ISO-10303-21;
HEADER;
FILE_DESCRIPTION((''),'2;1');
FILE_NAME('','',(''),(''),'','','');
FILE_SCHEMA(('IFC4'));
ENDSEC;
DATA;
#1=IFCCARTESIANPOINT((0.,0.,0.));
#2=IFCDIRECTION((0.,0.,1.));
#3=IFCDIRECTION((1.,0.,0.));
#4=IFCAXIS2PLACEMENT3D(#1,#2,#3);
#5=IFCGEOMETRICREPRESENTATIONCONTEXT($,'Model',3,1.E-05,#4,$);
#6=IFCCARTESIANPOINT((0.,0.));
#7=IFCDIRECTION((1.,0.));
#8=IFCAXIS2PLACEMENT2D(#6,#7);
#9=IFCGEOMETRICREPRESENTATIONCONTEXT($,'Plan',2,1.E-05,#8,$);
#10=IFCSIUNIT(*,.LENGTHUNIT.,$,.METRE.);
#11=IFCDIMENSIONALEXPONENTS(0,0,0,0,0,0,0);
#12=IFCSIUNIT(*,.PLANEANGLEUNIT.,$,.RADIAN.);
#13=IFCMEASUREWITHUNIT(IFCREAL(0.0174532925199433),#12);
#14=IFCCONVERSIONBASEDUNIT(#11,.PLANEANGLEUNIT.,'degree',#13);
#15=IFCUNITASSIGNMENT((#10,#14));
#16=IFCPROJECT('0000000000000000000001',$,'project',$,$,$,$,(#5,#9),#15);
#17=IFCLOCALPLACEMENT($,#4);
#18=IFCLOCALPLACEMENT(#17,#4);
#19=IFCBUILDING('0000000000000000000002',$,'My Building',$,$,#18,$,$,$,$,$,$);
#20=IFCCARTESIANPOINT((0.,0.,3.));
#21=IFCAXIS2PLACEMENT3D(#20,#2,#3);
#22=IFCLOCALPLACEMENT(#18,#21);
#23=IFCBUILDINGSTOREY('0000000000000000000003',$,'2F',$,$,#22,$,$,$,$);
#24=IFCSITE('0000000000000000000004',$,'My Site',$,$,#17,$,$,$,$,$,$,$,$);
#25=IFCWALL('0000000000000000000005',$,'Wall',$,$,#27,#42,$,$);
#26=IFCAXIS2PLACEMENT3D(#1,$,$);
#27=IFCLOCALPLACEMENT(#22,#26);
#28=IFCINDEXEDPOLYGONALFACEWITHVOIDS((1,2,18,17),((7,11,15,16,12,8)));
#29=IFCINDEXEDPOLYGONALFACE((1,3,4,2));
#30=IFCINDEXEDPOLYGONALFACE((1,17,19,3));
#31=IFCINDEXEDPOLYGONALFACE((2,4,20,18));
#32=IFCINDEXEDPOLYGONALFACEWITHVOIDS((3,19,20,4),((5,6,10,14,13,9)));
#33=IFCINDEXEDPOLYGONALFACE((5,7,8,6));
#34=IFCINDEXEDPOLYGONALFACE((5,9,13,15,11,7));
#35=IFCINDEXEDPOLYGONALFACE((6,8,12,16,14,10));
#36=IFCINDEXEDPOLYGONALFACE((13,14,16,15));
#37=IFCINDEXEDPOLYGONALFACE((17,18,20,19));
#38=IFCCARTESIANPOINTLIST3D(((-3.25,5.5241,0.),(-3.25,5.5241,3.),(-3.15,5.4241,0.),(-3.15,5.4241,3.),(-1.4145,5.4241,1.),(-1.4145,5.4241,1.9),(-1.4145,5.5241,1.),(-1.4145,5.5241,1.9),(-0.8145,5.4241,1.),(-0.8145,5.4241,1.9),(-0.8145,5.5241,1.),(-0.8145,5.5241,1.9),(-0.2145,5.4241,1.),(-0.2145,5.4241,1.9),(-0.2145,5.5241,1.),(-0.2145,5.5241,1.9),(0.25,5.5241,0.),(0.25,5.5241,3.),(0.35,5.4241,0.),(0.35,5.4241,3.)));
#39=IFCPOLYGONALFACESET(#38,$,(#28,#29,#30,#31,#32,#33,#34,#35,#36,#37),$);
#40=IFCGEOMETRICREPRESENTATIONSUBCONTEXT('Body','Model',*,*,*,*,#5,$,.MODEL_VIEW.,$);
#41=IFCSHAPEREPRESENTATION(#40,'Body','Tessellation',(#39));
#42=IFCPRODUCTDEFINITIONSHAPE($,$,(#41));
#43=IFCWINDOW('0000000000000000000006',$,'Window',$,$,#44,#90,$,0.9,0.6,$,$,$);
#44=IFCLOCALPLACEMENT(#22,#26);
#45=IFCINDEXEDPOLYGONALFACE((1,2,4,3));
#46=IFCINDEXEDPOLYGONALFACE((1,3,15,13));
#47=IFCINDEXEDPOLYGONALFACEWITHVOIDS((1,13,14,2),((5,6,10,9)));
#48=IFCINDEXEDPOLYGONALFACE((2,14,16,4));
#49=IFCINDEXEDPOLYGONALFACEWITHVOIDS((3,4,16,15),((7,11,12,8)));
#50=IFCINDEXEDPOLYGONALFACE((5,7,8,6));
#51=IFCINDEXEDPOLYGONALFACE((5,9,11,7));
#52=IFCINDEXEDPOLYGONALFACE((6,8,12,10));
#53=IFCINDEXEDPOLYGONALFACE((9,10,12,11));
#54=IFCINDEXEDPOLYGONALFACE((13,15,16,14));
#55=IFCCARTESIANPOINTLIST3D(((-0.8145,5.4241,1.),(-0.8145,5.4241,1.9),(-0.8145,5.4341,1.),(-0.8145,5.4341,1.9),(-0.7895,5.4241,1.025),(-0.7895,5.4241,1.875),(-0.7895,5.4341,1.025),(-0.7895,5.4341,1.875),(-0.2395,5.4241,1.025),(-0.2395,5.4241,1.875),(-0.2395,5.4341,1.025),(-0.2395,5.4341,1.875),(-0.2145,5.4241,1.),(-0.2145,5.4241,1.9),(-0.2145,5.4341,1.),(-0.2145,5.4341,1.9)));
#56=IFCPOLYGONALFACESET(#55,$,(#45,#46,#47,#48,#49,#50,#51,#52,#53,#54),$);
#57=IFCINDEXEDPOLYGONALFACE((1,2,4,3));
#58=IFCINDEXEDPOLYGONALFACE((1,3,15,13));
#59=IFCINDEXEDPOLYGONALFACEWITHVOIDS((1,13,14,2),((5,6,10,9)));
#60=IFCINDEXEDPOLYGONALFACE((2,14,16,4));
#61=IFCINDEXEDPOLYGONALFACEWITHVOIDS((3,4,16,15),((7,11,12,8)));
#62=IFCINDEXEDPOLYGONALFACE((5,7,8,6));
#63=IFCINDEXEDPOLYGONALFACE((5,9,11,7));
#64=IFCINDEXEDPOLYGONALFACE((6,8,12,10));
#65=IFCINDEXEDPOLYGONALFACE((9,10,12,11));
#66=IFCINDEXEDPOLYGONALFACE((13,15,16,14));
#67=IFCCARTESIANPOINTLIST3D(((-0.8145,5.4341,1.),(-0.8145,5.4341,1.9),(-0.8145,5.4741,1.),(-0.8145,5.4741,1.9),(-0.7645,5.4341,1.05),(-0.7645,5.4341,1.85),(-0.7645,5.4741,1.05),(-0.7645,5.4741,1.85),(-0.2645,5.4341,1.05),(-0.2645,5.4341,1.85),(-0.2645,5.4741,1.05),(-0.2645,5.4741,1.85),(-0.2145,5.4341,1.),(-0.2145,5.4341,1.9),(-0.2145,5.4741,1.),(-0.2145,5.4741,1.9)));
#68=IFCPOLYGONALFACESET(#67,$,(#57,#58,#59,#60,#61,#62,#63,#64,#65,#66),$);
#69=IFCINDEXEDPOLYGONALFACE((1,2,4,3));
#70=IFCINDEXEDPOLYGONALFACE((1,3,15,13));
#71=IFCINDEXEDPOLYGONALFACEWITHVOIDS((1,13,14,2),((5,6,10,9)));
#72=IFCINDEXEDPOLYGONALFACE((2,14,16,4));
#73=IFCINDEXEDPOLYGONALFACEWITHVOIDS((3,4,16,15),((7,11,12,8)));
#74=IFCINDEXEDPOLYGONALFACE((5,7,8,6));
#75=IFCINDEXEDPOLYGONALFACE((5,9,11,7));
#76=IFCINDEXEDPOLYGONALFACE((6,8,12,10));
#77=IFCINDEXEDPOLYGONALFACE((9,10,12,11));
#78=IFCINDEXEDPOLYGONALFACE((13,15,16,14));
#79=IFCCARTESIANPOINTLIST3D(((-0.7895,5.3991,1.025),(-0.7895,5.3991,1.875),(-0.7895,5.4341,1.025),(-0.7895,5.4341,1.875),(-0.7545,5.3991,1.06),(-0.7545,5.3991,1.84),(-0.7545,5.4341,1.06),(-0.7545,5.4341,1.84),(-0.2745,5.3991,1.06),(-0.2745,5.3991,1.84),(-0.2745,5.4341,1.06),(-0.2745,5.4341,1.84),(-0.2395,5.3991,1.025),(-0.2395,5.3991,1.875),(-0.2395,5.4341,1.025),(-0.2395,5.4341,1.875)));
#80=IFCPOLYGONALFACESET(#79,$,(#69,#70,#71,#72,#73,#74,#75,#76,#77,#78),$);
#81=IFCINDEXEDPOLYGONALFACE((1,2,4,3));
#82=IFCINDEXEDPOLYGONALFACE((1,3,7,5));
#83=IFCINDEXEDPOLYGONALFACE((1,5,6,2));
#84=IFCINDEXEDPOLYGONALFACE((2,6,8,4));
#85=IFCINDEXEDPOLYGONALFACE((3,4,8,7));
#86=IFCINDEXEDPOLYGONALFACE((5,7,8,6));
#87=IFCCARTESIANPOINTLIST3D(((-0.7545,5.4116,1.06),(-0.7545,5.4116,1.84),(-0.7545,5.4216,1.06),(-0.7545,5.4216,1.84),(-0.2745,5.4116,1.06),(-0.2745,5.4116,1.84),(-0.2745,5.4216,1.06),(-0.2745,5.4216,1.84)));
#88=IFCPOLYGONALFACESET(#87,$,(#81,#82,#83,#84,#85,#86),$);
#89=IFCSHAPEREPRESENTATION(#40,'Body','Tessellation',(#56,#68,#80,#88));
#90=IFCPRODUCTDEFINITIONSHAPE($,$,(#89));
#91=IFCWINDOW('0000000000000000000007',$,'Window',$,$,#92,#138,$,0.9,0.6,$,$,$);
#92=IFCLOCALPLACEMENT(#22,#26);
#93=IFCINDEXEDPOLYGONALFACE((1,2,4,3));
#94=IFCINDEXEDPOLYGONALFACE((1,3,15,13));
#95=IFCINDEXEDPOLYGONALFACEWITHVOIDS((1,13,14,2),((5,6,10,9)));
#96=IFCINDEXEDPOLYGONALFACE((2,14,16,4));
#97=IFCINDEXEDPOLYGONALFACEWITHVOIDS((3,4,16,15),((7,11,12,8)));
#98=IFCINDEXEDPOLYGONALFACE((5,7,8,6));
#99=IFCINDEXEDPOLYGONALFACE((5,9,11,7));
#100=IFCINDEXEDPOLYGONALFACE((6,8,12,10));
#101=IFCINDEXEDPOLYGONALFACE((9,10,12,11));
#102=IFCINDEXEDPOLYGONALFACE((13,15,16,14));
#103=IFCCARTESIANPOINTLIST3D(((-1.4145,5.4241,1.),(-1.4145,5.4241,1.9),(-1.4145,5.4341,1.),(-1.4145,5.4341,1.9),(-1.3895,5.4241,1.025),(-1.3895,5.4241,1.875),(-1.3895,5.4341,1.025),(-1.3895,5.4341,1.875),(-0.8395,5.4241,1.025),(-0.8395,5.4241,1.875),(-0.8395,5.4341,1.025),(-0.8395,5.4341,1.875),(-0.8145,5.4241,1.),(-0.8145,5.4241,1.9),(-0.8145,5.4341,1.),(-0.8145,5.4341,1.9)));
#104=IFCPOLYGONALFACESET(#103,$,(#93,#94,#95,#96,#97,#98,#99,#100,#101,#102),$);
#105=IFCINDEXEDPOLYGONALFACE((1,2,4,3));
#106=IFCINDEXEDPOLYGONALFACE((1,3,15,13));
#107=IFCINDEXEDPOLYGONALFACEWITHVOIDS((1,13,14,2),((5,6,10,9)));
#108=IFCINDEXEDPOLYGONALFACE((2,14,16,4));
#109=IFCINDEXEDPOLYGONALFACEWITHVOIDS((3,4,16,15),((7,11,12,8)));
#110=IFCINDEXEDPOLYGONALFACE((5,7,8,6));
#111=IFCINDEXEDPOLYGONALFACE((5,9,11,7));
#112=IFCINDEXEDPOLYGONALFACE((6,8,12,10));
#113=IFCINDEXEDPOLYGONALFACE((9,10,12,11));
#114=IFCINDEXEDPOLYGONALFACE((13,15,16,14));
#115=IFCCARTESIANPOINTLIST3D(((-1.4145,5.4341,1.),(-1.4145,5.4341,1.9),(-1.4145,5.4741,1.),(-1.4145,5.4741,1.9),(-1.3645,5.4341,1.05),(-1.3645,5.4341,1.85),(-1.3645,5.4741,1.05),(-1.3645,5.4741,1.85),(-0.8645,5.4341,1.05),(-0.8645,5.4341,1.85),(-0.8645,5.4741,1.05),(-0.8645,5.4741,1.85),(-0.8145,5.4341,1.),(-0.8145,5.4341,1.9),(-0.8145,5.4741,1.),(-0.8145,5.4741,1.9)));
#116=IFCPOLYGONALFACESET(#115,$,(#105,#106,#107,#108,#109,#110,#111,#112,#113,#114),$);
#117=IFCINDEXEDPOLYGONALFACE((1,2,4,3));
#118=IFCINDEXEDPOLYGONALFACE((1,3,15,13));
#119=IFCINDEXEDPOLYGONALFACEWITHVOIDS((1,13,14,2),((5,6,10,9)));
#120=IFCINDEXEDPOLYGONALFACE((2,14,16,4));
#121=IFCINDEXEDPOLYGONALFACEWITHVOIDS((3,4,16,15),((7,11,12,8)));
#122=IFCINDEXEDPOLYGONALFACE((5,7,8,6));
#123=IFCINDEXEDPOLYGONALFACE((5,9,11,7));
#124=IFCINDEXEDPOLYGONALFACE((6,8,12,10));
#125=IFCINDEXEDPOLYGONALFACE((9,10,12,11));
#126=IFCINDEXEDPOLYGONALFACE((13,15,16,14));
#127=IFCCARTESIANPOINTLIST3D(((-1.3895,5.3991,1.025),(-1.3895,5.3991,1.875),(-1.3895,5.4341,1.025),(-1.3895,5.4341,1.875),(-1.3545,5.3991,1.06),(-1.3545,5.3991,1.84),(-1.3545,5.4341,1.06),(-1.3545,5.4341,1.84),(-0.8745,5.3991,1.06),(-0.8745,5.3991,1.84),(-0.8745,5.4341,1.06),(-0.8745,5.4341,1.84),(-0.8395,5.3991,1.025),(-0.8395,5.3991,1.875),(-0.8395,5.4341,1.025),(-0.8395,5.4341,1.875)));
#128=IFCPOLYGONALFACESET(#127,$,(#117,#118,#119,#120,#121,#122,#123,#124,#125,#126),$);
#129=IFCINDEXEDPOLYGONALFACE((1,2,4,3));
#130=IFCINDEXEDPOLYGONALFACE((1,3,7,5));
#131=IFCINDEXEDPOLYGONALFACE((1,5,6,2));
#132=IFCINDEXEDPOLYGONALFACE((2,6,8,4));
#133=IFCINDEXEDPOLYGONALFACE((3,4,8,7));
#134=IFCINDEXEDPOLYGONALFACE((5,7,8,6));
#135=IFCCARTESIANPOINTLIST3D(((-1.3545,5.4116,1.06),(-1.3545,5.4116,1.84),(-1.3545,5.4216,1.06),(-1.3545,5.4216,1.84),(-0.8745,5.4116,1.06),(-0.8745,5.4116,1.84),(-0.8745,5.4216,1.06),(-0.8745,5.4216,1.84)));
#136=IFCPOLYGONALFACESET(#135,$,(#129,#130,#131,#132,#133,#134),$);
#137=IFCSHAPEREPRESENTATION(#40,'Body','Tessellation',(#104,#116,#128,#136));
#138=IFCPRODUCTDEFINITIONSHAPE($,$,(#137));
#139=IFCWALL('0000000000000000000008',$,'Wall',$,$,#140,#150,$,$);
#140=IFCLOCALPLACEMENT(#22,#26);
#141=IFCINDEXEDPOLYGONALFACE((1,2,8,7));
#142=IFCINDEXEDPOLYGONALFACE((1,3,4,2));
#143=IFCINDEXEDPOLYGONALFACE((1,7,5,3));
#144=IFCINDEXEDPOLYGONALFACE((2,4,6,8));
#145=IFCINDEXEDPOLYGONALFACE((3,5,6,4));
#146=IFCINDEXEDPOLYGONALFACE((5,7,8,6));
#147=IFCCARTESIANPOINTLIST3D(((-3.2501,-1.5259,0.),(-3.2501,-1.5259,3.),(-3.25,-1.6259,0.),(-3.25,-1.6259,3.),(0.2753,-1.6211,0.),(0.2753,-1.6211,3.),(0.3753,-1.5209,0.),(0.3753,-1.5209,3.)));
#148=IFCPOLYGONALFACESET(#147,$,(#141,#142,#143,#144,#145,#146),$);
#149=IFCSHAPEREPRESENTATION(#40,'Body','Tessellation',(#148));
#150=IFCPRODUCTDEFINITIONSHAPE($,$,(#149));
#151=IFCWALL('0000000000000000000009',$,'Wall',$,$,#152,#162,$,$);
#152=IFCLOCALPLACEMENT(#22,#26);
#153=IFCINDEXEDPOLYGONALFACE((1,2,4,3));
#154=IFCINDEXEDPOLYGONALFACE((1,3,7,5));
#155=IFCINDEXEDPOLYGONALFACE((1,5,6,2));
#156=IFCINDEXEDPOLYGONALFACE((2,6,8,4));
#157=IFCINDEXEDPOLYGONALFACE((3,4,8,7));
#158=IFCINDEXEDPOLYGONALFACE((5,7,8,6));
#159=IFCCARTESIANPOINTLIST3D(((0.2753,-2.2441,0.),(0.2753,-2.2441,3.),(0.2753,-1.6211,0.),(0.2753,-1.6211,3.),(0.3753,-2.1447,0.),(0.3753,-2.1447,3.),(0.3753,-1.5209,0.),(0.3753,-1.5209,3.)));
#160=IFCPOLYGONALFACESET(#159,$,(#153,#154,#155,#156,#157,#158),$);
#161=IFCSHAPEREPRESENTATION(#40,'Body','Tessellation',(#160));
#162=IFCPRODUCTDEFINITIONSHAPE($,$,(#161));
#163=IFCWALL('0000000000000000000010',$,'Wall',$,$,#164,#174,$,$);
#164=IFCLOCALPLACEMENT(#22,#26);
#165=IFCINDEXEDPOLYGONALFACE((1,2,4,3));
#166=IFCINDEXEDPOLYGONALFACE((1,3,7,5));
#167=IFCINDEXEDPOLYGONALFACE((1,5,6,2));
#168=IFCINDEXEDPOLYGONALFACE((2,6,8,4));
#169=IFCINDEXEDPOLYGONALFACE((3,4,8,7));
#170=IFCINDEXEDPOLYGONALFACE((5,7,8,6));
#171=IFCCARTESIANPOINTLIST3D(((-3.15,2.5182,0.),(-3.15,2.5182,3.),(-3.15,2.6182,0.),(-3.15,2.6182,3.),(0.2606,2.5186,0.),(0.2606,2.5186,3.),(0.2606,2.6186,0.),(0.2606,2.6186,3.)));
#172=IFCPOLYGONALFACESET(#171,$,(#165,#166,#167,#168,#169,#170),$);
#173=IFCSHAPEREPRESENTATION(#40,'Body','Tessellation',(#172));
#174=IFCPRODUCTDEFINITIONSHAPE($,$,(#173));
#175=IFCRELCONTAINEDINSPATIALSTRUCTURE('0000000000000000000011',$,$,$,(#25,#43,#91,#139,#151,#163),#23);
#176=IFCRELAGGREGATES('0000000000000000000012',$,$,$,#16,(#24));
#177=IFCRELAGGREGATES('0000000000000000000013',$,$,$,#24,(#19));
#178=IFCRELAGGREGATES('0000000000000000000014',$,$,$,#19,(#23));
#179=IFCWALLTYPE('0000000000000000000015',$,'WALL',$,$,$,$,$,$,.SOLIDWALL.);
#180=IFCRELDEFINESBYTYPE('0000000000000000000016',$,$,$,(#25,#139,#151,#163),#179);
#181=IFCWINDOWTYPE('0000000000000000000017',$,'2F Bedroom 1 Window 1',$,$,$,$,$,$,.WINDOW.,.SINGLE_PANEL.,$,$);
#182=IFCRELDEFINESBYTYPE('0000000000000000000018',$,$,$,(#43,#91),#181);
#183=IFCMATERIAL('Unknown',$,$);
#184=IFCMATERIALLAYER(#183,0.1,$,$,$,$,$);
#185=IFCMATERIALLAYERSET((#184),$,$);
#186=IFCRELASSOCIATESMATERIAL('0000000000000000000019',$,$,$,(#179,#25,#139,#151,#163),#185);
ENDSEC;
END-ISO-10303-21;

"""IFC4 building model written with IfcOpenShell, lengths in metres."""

from ifc_helpers import new_model, entity, si_unit, converted_unit, frame, origin_with_axes, origin_2d_with_axis, place, context, subcontext, project, spatial, line, indexed_curve, outline, extrude, shape, source, transform, mapped, material, layer, layer_set, layer_usage, type_object, type_shapes, element, fill, save


model = new_model("IFC4")

# Units and contexts
model_context = context("Model", 3, precision=1e-05, world=origin_with_axes())
plan_context = context("Plan", 2, precision=1e-05, world=origin_2d_with_axis())
body_context_1 = subcontext(model_context, "Body", "Model", "MODEL_VIEW")
body_context_2 = subcontext(plan_context, "Body", "Plan", "PLAN_VIEW")
ifc_project = project(units=[si_unit("LENGTHUNIT", "METRE"), converted_unit("PLANEANGLEUNIT", "degree", entity("IfcReal", 0.0174532925199433), si_unit("PLANEANGLEUNIT", "RADIAN"), dimensions=[0, 0, 0, 0, 0, 0, 0])], contexts=[model_context, plan_context])

# Site, building, storey
site_placement = place(None, origin_with_axes())
site = spatial("IfcSite", under=ifc_project, at=site_placement, Name="My Site")
building_placement = place(site_placement, origin_with_axes())
building = spatial("IfcBuilding", under=site, at=building_placement, Name="My Building")
storey_placement = place(building_placement, frame((0.0, 0.0, 3.0), z_axis=(0.0, 0.0, 1.0), x_axis=(1.0, 0.0, 0.0)))
storey = spatial("IfcBuildingStorey", under=building, at=storey_placement, Name="2F")

# Shared definitions
ifc_material = material(Name="Unknown")

# Shared definitions
ifc_layer_1 = layer(ifc_material, 0.1)
ifc_layer_set_1 = layer_set([ifc_layer_1])
wall_type = type_object("IfcWallType", Name="WALL", PredefinedType="SOLIDWALL", material=ifc_layer_set_1)

# Wall, openings, windows
ifc_layer_usage_1 = layer_usage(ifc_layer_set_1, "AXIS2", "POSITIVE", 0.0)
wall_1_placement = place(storey_placement, frame((0.25, 5.5241, 0.0), z_axis=(0.0, 0.0, 1.0), x_axis=(-1.0, 0.0, 0.0)))
wall_1 = element("IfcWall", 1, at=wall_1_placement, inside=storey, type_object=wall_type, material=ifc_layer_usage_1, Name="Wall", context=body_context_1, shape_type="SweptSolid", body=[
    extrude(outline(indexed_curve([(0.0, 0.0), (-0.1, 0.1), (3.4, 0.1), (3.5, 0.0)], segments=[line(1, 2, 3, 4, 1)])), origin_with_axes(), (0.0, 0.0, 1.0), 3.0),
])
shared_shape_1 = source(origin_with_axes(), body_context_1, "Body", "SweptSolid", [
    extrude(outline(indexed_curve([(0.0, 0.0), (0.6, 0.0), (0.6, 0.9), (0.0, 0.9)], segments=[line(1, 2, 3, 4, 1)])), frame((0.0, -0.6, 0.0), z_axis=(0.0, -1.0, 0.0), x_axis=(1.0, 0.0, 0.0)), (0.0, 0.0, -1.0), 1.2),
])
opening_1_placement = place(wall_1_placement, frame((0.4645, 0.0, 1.0), z_axis=(0.0, 0.0, 1.0), x_axis=(1.0, 0.0, 0.0)))
opening_1 = element("IfcOpeningElement", 2, at=opening_1_placement, cuts=wall_1, PredefinedType="OPENING", context=body_context_1, shape_type="MappedRepresentation", body=[
    mapped(shared_shape_1, transform((0.0, 0.0, 0.0), x_axis=(1.0, 0.0, 0.0), y_axis=(0.0, 1.0, 0.0), z_axis=(0.0, 0.0, 1.0), scale=1.0)),
])
opening_2_placement = place(wall_1_placement, frame((1.0645, 0.0, 1.0), z_axis=(0.0, 0.0, 1.0), x_axis=(1.0, 0.0, 0.0)))
opening_2 = element("IfcOpeningElement", 3, at=opening_2_placement, cuts=wall_1, PredefinedType="OPENING", context=body_context_1, shape_type="MappedRepresentation", body=[
    mapped(shared_shape_1, transform((0.0, 0.0, 0.0), x_axis=(1.0, 0.0, 0.0), y_axis=(0.0, 1.0, 0.0), z_axis=(0.0, 0.0, 1.0), scale=1.0)),
])
window_type_1 = type_object("IfcWindowType", Name="2F Bedroom 1 Window 1", PartitioningType="SINGLE_PANEL", PredefinedType="WINDOW")
shared_shape_2 = source(origin_with_axes(), body_context_1, "Body", "SweptSolid", [
    extrude(outline(indexed_curve([(0.0, 0.0), (0.6, 0.0), (0.6, 0.9), (0.0, 0.9)], segments=[line(1, 2, 3, 4, 1)]), holes=[indexed_curve([(0.025, 0.025), (0.575, 0.025), (0.575, 0.875), (0.025, 0.875)], segments=[line(1, 2, 3, 4, 1)])]), frame((0.0, 0.09, 0.0), z_axis=(0.0, -1.0, 0.0), x_axis=(1.0, 0.0, 0.0)), (0.0, 0.0, -1.0), 0.01),
    extrude(outline(indexed_curve([(0.0, 0.0), (0.6, 0.0), (0.6, 0.9), (0.0, 0.9)], segments=[line(1, 2, 3, 4, 1)]), holes=[indexed_curve([(0.05, 0.05), (0.55, 0.05), (0.55, 0.85), (0.05, 0.85)], segments=[line(1, 2, 3, 4, 1)])]), frame((0.0, 0.05, 0.0), z_axis=(0.0, -1.0, 0.0), x_axis=(1.0, 0.0, 0.0)), (0.0, 0.0, -1.0), 0.04),
    extrude(outline(indexed_curve([(0.0, 0.0), (0.55, 0.0), (0.55, 0.85), (0.0, 0.85)], segments=[line(1, 2, 3, 4, 1)]), holes=[indexed_curve([(0.035, 0.035), (0.515, 0.035), (0.515, 0.815), (0.035, 0.815)], segments=[line(1, 2, 3, 4, 1)])]), frame((0.025, 0.09, 0.025), z_axis=(0.0, -1.0, 0.0), x_axis=(1.0, 0.0, 0.0)), (0.0, 0.0, -1.0), 0.035),
    extrude(outline(indexed_curve([(0.035, 0.035), (0.515, 0.035), (0.515, 0.815), (0.035, 0.815)], segments=[line(1, 2, 3, 4, 1)])), frame((0.025, 0.1025, 0.025), z_axis=(0.0, -1.0, 0.0), x_axis=(1.0, 0.0, 0.0)), (0.0, 0.0, -1.0), 0.01),
])
shared_shape_3 = source(origin_with_axes(), body_context_2, "Body", "Curve2D", [
    entity("IfcIndexedPolyCurve", entity("IfcCartesianPointList2D", [[0.05, 0.05], [0.55, 0.05]])),
    entity("IfcIndexedPolyCurve", entity("IfcCartesianPointList2D", [[0.0, 0.1], [0.025, 0.1], [0.025, 0.09], [0.05, 0.09], [0.05, 0.05], [0.0, 0.05]]), [entity("IfcLineIndex", [1, 2, 3, 4, 5, 6, 1])]),
    entity("IfcIndexedPolyCurve", entity("IfcCartesianPointList2D", [[0.6, 0.1], [0.575, 0.1], [0.575, 0.09], [0.55, 0.09], [0.55, 0.05], [0.6, 0.05]]), [entity("IfcLineIndex", [1, 2, 3, 4, 5, 6, 1])]),
    entity("IfcIndexedPolyCurve", entity("IfcCartesianPointList2D", [[0.025, 0.09], [0.06, 0.09], [0.06, 0.125], [0.025, 0.125]]), [entity("IfcLineIndex", [1, 2, 3, 4, 1])]),
    entity("IfcIndexedPolyCurve", entity("IfcCartesianPointList2D", [[0.575, 0.09], [0.54, 0.09], [0.54, 0.125], [0.575, 0.125]]), [entity("IfcLineIndex", [1, 2, 3, 4, 1])]),
    entity("IfcIndexedPolyCurve", entity("IfcCartesianPointList2D", [[0.06, 0.09], [0.54, 0.09]])),
    entity("IfcIndexedPolyCurve", entity("IfcCartesianPointList2D", [[0.06, 0.125], [0.54, 0.125]])),
    entity("IfcIndexedPolyCurve", entity("IfcCartesianPointList2D", [[0.06, 0.1075], [0.54, 0.1075]])),
])
type_shapes(window_type_1, [shared_shape_2, shared_shape_3])
window_1_placement = place(opening_1_placement, frame((0.0, 0.0, 0.0), z_axis=(0.0, 0.0, 1.0), x_axis=(1.0, 0.0, 0.0)))
window_1 = element("IfcWindow", 4, at=window_1_placement, inside=storey, type_object=window_type_1, Name="Window", OverallHeight=0.9, OverallWidth=0.6, shapes=[
    shape(body_context_1, "Body", "MappedRepresentation", [mapped(shared_shape_2, transform((0.0, 0.0, 0.0), x_axis=(1.0, 0.0, 0.0), y_axis=(0.0, 1.0, 0.0), z_axis=(0.0, 0.0, 1.0), scale=1.0))]),
    shape(body_context_2, "Body", "MappedRepresentation", [mapped(shared_shape_3, transform((0.0, 0.0, 0.0), x_axis=(1.0, 0.0, 0.0), y_axis=(0.0, 1.0, 0.0), z_axis=(0.0, 0.0, 1.0), scale=1.0))]),
])
fill(opening_1, window_1)
window_2_placement = place(opening_2_placement, frame((0.0, 0.0, 0.0), z_axis=(0.0, 0.0, 1.0), x_axis=(1.0, 0.0, 0.0)))
window_2 = element("IfcWindow", 5, at=window_2_placement, inside=storey, type_object=window_type_1, Name="Window", OverallHeight=0.9, OverallWidth=0.6, shapes=[
    shape(body_context_1, "Body", "MappedRepresentation", [mapped(shared_shape_2, transform((0.0, 0.0, 0.0), x_axis=(1.0, 0.0, 0.0), y_axis=(0.0, 1.0, 0.0), z_axis=(0.0, 0.0, 1.0), scale=1.0))]),
    shape(body_context_2, "Body", "MappedRepresentation", [mapped(shared_shape_3, transform((0.0, 0.0, 0.0), x_axis=(1.0, 0.0, 0.0), y_axis=(0.0, 1.0, 0.0), z_axis=(0.0, 0.0, 1.0), scale=1.0))]),
])
fill(opening_2, window_2)

# Walls
ifc_layer_usage_2 = layer_usage(ifc_layer_set_1, "AXIS2", "POSITIVE", 0.0)
wall_2_placement = place(storey_placement, frame((-3.25, -1.6259, 0.0), z_axis=(0.0, 0.0, 1.0), x_axis=(0.999999, 0.001371, 0.0)))
element("IfcWall", 6, at=wall_2_placement, inside=storey, type_object=wall_type, material=ifc_layer_usage_2, Name="Wall", context=body_context_1, shape_type="SweptSolid", body=[
    extrude(outline(indexed_curve([(0.0, 0.0), (0.0, 0.1), (3.6254, 0.1), (3.5253, 0.0)], segments=[line(1, 2, 3, 4, 1)])), origin_with_axes(), (0.0, 0.0, 1.0), 3.0),
])
ifc_layer_usage_3 = layer_usage(ifc_layer_set_1, "AXIS2", "POSITIVE", 0.0)
wall_3_placement = place(storey_placement, frame((0.2753, -1.6211, 0.0), z_axis=(0.0, 0.0, 1.0), x_axis=(0.0, -1.0, 0.0)))
element("IfcWall", 7, at=wall_3_placement, inside=storey, type_object=wall_type, material=ifc_layer_usage_3, Name="Wall", context=body_context_1, shape_type="SweptSolid", body=[
    extrude(outline(indexed_curve([(0.0, 0.0), (-0.1001, 0.1), (0.5237, 0.1), (0.623, 0.0)], segments=[line(1, 2, 3, 4, 1)])), origin_with_axes(), (0.0, 0.0, 1.0), 3.0),
])

# Wall
ifc_layer_usage_4 = layer_usage(ifc_layer_set_1, "AXIS2", "POSITIVE", 0.0)
wall_4_placement = place(storey_placement, frame((-3.15, 2.5182, 0.0), z_axis=(0.0, 0.0, 1.0), x_axis=(1.0, 0.000117, 0.0)))
element("IfcWall", 8, at=wall_4_placement, inside=storey, type_object=wall_type, material=ifc_layer_usage_4, Name="Wall", context=body_context_1, shape_type="SweptSolid", body=[
    extrude(outline(indexed_curve([(0.0, 0.0), (0.0, 0.1), (3.4106, 0.1), (3.4106, 0.0)], segments=[line(1, 2, 3, 4, 1)])), origin_with_axes(), (0.0, 0.0, 1.0), 3.0),
])

save(model, "model.ifc")
